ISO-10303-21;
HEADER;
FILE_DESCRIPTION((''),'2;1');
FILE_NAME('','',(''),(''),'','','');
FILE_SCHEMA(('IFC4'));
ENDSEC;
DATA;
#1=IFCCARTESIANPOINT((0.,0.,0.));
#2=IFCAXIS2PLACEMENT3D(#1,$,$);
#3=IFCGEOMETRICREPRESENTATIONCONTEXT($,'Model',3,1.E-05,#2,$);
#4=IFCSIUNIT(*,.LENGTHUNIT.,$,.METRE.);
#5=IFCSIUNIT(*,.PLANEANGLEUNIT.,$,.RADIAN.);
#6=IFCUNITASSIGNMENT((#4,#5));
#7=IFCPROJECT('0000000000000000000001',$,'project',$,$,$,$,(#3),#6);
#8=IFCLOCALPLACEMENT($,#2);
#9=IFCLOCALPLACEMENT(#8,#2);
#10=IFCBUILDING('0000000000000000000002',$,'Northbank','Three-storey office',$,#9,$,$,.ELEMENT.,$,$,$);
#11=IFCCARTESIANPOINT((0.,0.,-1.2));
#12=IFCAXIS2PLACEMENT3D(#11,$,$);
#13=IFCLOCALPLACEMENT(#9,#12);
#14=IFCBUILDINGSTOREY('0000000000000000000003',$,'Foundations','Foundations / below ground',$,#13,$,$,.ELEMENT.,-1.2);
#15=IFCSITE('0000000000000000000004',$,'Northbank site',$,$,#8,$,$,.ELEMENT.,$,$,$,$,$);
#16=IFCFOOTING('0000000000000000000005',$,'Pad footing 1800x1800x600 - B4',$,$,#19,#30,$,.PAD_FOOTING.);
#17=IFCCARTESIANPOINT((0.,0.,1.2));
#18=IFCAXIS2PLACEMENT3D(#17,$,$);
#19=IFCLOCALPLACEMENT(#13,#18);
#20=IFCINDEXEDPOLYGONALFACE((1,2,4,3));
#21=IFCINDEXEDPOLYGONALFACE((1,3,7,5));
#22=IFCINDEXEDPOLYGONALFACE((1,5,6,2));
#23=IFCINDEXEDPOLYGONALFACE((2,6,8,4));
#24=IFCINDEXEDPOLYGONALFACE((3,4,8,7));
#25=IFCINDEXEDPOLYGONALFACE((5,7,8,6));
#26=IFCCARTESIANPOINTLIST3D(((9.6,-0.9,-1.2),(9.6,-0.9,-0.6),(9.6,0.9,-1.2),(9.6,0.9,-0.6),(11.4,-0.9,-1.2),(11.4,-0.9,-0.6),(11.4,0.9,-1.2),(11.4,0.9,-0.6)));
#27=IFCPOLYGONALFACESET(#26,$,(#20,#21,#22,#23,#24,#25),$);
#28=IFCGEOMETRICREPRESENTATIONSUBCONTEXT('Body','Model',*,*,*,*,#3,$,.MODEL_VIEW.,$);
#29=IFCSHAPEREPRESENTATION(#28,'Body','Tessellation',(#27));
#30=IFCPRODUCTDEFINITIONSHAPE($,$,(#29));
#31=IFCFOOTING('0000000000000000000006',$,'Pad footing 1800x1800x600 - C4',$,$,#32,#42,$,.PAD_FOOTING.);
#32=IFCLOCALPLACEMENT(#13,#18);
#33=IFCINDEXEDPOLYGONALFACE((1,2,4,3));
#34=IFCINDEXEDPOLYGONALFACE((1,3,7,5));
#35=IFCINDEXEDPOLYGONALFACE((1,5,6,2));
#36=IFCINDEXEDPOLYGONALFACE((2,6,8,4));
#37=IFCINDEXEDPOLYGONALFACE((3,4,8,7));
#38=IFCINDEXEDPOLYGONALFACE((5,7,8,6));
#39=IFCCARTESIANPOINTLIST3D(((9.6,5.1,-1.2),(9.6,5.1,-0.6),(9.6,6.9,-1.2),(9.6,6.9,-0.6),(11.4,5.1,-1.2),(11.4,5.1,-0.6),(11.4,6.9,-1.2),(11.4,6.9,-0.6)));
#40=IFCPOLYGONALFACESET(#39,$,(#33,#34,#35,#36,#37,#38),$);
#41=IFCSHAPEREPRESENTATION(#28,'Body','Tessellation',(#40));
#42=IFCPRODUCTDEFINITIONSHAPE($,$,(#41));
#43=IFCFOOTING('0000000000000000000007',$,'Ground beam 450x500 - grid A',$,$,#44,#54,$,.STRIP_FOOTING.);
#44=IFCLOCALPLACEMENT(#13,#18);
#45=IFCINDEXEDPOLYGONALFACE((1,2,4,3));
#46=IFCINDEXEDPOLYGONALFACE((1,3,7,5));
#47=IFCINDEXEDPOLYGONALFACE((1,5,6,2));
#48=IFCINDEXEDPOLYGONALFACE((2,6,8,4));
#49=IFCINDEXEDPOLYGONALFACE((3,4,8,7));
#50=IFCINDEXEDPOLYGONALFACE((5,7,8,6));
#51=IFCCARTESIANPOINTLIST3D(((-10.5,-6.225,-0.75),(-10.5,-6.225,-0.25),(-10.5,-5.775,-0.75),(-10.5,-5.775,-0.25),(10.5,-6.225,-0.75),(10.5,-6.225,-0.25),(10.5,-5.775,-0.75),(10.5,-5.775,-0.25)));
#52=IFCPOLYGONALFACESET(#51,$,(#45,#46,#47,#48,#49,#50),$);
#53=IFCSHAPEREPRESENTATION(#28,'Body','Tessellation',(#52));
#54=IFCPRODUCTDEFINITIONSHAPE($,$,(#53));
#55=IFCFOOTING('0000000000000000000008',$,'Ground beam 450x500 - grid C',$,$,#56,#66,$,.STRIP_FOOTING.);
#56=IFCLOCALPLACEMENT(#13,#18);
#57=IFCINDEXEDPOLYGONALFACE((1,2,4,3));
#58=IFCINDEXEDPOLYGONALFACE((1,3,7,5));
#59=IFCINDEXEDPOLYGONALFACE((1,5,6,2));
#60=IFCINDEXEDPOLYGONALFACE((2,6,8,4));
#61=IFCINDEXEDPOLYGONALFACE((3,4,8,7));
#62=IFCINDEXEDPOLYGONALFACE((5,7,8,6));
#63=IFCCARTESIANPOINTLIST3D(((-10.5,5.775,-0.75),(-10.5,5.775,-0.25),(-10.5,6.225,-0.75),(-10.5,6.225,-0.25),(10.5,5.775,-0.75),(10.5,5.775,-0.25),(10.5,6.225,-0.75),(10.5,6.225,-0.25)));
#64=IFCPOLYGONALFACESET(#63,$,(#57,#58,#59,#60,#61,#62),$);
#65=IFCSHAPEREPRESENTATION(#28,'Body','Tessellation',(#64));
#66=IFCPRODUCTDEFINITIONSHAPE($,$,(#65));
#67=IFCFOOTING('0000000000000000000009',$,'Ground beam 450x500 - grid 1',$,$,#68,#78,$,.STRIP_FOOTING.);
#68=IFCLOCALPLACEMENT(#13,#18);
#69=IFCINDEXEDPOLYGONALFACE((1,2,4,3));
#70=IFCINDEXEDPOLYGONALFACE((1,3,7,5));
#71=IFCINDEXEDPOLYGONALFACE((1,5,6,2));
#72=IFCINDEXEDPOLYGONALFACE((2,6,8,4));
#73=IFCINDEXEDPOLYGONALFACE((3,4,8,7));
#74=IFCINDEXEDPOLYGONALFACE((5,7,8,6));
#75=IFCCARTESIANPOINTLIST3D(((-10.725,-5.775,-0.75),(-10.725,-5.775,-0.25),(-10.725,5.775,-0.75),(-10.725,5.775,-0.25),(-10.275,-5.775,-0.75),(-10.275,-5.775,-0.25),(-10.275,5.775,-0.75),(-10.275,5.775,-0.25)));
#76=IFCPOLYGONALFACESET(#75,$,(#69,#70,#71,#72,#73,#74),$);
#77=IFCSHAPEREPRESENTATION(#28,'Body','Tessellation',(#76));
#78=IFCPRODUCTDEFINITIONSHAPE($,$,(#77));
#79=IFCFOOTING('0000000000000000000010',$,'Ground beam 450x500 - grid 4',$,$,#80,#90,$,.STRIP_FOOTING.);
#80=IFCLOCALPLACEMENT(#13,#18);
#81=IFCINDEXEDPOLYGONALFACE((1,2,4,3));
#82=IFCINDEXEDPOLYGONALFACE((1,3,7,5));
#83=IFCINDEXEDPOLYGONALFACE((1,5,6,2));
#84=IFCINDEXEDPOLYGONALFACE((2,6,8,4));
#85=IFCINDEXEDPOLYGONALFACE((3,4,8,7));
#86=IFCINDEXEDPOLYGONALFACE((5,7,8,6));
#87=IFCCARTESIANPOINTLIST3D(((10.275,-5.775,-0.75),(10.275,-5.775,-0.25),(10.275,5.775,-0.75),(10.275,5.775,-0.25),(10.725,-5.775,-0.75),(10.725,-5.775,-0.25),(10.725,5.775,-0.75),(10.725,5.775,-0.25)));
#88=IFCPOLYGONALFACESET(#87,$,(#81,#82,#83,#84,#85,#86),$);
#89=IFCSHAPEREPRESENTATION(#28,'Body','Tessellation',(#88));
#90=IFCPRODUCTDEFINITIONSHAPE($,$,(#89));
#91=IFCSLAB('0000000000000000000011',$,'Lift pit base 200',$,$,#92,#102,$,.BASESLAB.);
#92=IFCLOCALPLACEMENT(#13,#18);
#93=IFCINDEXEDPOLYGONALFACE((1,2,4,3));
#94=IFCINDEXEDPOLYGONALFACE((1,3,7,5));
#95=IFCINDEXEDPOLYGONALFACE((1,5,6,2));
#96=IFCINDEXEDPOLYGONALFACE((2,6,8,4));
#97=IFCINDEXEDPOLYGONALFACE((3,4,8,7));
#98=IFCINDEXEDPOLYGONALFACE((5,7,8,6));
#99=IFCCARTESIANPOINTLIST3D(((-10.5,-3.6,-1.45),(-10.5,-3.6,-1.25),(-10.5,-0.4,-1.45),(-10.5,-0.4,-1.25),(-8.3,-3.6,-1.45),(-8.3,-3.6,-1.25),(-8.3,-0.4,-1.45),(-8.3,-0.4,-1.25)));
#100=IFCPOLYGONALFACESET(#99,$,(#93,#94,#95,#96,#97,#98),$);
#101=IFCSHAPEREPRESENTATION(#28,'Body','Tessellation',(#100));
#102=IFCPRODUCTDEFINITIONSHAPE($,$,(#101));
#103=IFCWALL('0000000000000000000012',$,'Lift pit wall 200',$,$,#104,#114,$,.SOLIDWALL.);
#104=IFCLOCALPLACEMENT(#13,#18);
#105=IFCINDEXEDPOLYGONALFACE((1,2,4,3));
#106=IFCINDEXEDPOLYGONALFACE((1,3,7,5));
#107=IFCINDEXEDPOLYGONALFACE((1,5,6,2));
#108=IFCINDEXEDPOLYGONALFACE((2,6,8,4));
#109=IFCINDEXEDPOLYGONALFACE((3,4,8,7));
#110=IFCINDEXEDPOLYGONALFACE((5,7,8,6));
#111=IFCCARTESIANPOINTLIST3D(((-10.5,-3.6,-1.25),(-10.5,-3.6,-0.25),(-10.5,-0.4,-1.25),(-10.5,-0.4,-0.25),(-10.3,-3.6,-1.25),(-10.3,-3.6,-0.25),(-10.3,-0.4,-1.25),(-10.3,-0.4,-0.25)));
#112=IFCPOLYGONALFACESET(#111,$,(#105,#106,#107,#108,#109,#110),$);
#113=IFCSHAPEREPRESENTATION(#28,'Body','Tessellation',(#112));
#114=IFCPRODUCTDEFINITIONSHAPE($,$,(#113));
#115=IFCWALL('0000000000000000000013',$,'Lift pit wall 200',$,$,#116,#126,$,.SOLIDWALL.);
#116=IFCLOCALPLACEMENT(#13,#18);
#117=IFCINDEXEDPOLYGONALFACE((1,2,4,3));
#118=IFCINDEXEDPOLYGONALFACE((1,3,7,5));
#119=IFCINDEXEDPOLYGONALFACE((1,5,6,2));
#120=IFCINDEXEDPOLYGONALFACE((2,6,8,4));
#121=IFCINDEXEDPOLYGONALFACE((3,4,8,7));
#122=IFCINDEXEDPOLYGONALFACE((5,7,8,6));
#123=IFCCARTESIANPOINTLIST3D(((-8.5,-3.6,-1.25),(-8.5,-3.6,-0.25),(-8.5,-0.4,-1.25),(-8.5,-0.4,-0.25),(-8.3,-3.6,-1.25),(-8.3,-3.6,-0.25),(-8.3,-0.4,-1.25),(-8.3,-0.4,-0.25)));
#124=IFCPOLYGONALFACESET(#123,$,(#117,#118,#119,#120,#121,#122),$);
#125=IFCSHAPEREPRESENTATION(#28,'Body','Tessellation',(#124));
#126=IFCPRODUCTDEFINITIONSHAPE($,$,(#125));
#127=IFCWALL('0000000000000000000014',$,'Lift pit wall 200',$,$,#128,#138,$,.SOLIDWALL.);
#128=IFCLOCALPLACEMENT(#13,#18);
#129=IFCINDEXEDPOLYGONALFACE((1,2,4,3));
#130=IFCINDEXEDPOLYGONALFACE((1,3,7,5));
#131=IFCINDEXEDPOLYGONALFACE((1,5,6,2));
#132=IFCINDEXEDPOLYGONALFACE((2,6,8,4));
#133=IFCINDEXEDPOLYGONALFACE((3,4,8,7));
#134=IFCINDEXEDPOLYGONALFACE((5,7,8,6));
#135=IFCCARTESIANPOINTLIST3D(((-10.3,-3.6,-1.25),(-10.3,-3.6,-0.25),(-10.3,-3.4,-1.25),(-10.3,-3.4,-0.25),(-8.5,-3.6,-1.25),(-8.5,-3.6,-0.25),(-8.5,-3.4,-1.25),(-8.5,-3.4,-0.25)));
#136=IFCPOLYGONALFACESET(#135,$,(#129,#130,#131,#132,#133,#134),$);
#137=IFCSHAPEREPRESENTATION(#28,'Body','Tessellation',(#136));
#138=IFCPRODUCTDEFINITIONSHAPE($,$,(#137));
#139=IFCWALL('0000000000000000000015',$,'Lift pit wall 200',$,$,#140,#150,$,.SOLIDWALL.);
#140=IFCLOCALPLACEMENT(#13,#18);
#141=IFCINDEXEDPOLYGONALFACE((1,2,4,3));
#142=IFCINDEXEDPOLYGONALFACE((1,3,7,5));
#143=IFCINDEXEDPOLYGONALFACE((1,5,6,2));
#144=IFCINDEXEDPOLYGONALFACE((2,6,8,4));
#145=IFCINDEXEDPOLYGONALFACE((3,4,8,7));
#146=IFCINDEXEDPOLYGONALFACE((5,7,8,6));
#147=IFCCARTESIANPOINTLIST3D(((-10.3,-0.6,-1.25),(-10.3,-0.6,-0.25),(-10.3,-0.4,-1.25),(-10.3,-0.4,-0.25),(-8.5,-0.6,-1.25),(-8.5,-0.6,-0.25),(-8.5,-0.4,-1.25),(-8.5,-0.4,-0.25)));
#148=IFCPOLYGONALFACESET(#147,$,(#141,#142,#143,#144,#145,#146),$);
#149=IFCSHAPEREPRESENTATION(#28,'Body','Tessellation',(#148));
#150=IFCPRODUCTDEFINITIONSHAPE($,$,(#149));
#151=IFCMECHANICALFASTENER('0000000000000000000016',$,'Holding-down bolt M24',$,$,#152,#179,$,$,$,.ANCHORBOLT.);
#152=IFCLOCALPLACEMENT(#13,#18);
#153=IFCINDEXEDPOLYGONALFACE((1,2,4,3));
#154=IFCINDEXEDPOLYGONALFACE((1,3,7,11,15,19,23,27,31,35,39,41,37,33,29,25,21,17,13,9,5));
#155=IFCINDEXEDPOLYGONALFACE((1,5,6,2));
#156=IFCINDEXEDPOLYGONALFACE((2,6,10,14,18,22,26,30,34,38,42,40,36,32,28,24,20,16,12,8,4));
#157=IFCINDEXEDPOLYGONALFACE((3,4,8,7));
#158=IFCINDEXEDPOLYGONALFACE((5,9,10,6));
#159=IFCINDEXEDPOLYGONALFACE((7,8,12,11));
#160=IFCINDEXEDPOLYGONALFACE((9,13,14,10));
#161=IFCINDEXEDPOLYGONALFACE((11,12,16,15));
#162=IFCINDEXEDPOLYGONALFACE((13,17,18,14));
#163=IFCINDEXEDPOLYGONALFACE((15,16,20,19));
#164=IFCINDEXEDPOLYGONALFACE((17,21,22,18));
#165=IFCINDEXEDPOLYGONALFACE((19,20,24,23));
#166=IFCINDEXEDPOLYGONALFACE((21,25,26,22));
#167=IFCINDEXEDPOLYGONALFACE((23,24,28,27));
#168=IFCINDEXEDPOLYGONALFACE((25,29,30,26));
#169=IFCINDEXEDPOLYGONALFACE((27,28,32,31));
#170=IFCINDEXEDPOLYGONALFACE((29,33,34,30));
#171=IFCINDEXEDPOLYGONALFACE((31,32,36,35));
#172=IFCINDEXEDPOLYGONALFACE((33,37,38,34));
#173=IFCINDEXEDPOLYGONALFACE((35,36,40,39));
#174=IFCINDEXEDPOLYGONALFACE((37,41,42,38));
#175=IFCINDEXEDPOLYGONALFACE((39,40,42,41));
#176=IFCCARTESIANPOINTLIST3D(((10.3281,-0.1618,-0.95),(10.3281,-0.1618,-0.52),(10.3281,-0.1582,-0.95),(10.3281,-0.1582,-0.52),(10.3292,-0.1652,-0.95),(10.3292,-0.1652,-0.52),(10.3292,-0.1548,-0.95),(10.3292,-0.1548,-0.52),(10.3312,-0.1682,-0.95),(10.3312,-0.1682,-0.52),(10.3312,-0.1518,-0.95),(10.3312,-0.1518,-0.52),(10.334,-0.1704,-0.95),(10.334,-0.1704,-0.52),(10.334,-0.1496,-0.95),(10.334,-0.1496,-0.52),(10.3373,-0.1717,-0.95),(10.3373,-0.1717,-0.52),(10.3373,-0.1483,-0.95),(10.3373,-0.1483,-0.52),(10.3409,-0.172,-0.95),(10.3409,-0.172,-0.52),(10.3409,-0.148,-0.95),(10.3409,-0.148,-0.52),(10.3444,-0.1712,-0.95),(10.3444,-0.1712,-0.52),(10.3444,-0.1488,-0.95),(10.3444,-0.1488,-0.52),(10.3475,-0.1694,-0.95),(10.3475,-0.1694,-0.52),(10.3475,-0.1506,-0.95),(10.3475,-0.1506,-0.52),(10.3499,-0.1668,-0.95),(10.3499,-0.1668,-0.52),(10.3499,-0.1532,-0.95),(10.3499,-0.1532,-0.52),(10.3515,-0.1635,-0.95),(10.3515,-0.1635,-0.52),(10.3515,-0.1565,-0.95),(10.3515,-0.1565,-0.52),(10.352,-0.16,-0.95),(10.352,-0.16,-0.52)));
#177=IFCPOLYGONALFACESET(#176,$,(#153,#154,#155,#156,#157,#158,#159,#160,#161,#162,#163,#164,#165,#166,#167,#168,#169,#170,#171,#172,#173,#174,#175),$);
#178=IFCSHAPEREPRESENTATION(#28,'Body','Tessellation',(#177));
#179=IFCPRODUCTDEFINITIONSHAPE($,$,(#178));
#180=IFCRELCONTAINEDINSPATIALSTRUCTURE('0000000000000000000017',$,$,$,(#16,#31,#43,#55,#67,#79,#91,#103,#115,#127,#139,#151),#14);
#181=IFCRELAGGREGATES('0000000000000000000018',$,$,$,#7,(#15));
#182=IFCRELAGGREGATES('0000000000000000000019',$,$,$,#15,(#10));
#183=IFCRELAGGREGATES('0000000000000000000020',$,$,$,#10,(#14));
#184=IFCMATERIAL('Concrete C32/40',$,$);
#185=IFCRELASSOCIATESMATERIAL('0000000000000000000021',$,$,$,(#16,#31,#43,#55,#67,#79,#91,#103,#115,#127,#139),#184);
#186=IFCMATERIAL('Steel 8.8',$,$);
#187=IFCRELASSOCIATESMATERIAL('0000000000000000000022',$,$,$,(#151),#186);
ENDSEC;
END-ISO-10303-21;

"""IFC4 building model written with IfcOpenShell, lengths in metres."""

from ifc_helpers import new_model, si_unit, frame, origin, place, context, subcontext, project, spatial, rectangle, circle, extrude, material, element, save


model = new_model("IFC4")

# Units and contexts
model_context = context("Model", 3, precision=1e-05, world=origin())
body_context = subcontext(model_context, "Body", "Model", "MODEL_VIEW")
ifc_project = project(units=[si_unit("LENGTHUNIT", "METRE"), si_unit("PLANEANGLEUNIT", "RADIAN")], contexts=[model_context])

# Site, building, storey
site_placement = place(None, origin())
site = spatial("IfcSite", under=ifc_project, at=site_placement, Name="Northbank site", CompositionType="ELEMENT")
building_placement = place(site_placement, origin())
building = spatial("IfcBuilding", under=site, at=building_placement, Name="Northbank", Description="Three-storey office", CompositionType="ELEMENT")
storey_placement = place(building_placement, frame((0.0, 0.0, -1.2)))
storey = spatial("IfcBuildingStorey", under=building, at=storey_placement, Name="Foundations", Description="Foundations / below ground", CompositionType="ELEMENT", Elevation=-1.2)

# Footings
ifc_material_1 = material(Name="Concrete C32/40")
footing_1_placement = place(storey_placement, frame((0.0, 0.0, 1.2)))
element("IfcFooting", 1, at=footing_1_placement, inside=storey, material=ifc_material_1, Name="Pad footing 1800x1800x600 - B4", PredefinedType="PAD_FOOTING", context=body_context, shape_type="SweptSolid", body=[
    extrude(rectangle(XDim=1.8, YDim=1.8), frame((10.5, 0.0, -1.2)), (0.0, 0.0, 1.0), 0.6),
])
footing_2_placement = place(storey_placement, frame((0.0, 0.0, 1.2)))
element("IfcFooting", 2, at=footing_2_placement, inside=storey, material=ifc_material_1, Name="Pad footing 1800x1800x600 - C4", PredefinedType="PAD_FOOTING", context=body_context, shape_type="SweptSolid", body=[
    extrude(rectangle(XDim=1.8, YDim=1.8), frame((10.5, 6.0, -1.2)), (0.0, 0.0, 1.0), 0.6),
])
footing_3_placement = place(storey_placement, frame((0.0, 0.0, 1.2)))
element("IfcFooting", 3, at=footing_3_placement, inside=storey, material=ifc_material_1, Name="Ground beam 450x500 - grid A", PredefinedType="STRIP_FOOTING", context=body_context, shape_type="SweptSolid", body=[
    extrude(rectangle(XDim=21.0, YDim=0.45), frame((0.0, -6.0, -0.75)), (0.0, 0.0, 1.0), 0.5),
])
footing_4_placement = place(storey_placement, frame((0.0, 0.0, 1.2)))
element("IfcFooting", 4, at=footing_4_placement, inside=storey, material=ifc_material_1, Name="Ground beam 450x500 - grid C", PredefinedType="STRIP_FOOTING", context=body_context, shape_type="SweptSolid", body=[
    extrude(rectangle(XDim=21.0, YDim=0.45), frame((0.0, 6.0, -0.75)), (0.0, 0.0, 1.0), 0.5),
])
footing_5_placement = place(storey_placement, frame((0.0, 0.0, 1.2)))
element("IfcFooting", 5, at=footing_5_placement, inside=storey, material=ifc_material_1, Name="Ground beam 450x500 - grid 1", PredefinedType="STRIP_FOOTING", context=body_context, shape_type="SweptSolid", body=[
    extrude(rectangle(XDim=0.45, YDim=11.55), frame((-10.5, 0.0, -0.75)), (0.0, 0.0, 1.0), 0.5),
])
footing_6_placement = place(storey_placement, frame((0.0, 0.0, 1.2)))
element("IfcFooting", 6, at=footing_6_placement, inside=storey, material=ifc_material_1, Name="Ground beam 450x500 - grid 4", PredefinedType="STRIP_FOOTING", context=body_context, shape_type="SweptSolid", body=[
    extrude(rectangle(XDim=0.45, YDim=11.55), frame((10.5, 0.0, -0.75)), (0.0, 0.0, 1.0), 0.5),
])

# Slab
slab_placement = place(storey_placement, frame((0.0, 0.0, 1.2)))
element("IfcSlab", 7, at=slab_placement, inside=storey, material=ifc_material_1, Name="Lift pit base 200", PredefinedType="BASESLAB", context=body_context, shape_type="SweptSolid", body=[
    extrude(rectangle(XDim=2.2, YDim=3.2), frame((-9.4, -2.0, -1.45)), (0.0, 0.0, 1.0), 0.2),
])

# Walls
wall_1_placement = place(storey_placement, frame((0.0, 0.0, 1.2)))
element("IfcWall", 8, at=wall_1_placement, inside=storey, material=ifc_material_1, Name="Lift pit wall 200", PredefinedType="SOLIDWALL", context=body_context, shape_type="SweptSolid", body=[
    extrude(rectangle(XDim=0.2, YDim=3.2), frame((-10.4, -2.0, -1.25)), (0.0, 0.0, 1.0), 1.0),
])
wall_2_placement = place(storey_placement, frame((0.0, 0.0, 1.2)))
element("IfcWall", 9, at=wall_2_placement, inside=storey, material=ifc_material_1, Name="Lift pit wall 200", PredefinedType="SOLIDWALL", context=body_context, shape_type="SweptSolid", body=[
    extrude(rectangle(XDim=0.2, YDim=3.2), frame((-8.4, -2.0, -1.25)), (0.0, 0.0, 1.0), 1.0),
])
wall_3_placement = place(storey_placement, frame((0.0, 0.0, 1.2)))
element("IfcWall", 10, at=wall_3_placement, inside=storey, material=ifc_material_1, Name="Lift pit wall 200", PredefinedType="SOLIDWALL", context=body_context, shape_type="SweptSolid", body=[
    extrude(rectangle(XDim=1.8, YDim=0.2), frame((-9.4, -3.5, -1.25)), (0.0, 0.0, 1.0), 1.0),
])
wall_4_placement = place(storey_placement, frame((0.0, 0.0, 1.2)))
element("IfcWall", 11, at=wall_4_placement, inside=storey, material=ifc_material_1, Name="Lift pit wall 200", PredefinedType="SOLIDWALL", context=body_context, shape_type="SweptSolid", body=[
    extrude(rectangle(XDim=1.8, YDim=0.2), frame((-9.4, -0.5, -1.25)), (0.0, 0.0, 1.0), 1.0),
])

# Mechanical fastener
ifc_material_2 = material(Name="Steel 8.8")
mechanical_fastener_1_placement = place(storey_placement, frame((0.0, 0.0, 1.2)))
element("IfcMechanicalFastener", 12, at=mechanical_fastener_1_placement, inside=storey, material=ifc_material_2, Name="Holding-down bolt M24", PredefinedType="ANCHORBOLT", context=body_context, shape_type="SweptSolid", body=[
    extrude(circle(Radius=0.012), frame((10.34, -0.16, -0.95), z_axis=(0.0, 0.0, 1.0), x_axis=(1.0, 0.0, 0.0)), (0.0, 0.0, 1.0), 0.43),
])

save(model, "model.ifc")
